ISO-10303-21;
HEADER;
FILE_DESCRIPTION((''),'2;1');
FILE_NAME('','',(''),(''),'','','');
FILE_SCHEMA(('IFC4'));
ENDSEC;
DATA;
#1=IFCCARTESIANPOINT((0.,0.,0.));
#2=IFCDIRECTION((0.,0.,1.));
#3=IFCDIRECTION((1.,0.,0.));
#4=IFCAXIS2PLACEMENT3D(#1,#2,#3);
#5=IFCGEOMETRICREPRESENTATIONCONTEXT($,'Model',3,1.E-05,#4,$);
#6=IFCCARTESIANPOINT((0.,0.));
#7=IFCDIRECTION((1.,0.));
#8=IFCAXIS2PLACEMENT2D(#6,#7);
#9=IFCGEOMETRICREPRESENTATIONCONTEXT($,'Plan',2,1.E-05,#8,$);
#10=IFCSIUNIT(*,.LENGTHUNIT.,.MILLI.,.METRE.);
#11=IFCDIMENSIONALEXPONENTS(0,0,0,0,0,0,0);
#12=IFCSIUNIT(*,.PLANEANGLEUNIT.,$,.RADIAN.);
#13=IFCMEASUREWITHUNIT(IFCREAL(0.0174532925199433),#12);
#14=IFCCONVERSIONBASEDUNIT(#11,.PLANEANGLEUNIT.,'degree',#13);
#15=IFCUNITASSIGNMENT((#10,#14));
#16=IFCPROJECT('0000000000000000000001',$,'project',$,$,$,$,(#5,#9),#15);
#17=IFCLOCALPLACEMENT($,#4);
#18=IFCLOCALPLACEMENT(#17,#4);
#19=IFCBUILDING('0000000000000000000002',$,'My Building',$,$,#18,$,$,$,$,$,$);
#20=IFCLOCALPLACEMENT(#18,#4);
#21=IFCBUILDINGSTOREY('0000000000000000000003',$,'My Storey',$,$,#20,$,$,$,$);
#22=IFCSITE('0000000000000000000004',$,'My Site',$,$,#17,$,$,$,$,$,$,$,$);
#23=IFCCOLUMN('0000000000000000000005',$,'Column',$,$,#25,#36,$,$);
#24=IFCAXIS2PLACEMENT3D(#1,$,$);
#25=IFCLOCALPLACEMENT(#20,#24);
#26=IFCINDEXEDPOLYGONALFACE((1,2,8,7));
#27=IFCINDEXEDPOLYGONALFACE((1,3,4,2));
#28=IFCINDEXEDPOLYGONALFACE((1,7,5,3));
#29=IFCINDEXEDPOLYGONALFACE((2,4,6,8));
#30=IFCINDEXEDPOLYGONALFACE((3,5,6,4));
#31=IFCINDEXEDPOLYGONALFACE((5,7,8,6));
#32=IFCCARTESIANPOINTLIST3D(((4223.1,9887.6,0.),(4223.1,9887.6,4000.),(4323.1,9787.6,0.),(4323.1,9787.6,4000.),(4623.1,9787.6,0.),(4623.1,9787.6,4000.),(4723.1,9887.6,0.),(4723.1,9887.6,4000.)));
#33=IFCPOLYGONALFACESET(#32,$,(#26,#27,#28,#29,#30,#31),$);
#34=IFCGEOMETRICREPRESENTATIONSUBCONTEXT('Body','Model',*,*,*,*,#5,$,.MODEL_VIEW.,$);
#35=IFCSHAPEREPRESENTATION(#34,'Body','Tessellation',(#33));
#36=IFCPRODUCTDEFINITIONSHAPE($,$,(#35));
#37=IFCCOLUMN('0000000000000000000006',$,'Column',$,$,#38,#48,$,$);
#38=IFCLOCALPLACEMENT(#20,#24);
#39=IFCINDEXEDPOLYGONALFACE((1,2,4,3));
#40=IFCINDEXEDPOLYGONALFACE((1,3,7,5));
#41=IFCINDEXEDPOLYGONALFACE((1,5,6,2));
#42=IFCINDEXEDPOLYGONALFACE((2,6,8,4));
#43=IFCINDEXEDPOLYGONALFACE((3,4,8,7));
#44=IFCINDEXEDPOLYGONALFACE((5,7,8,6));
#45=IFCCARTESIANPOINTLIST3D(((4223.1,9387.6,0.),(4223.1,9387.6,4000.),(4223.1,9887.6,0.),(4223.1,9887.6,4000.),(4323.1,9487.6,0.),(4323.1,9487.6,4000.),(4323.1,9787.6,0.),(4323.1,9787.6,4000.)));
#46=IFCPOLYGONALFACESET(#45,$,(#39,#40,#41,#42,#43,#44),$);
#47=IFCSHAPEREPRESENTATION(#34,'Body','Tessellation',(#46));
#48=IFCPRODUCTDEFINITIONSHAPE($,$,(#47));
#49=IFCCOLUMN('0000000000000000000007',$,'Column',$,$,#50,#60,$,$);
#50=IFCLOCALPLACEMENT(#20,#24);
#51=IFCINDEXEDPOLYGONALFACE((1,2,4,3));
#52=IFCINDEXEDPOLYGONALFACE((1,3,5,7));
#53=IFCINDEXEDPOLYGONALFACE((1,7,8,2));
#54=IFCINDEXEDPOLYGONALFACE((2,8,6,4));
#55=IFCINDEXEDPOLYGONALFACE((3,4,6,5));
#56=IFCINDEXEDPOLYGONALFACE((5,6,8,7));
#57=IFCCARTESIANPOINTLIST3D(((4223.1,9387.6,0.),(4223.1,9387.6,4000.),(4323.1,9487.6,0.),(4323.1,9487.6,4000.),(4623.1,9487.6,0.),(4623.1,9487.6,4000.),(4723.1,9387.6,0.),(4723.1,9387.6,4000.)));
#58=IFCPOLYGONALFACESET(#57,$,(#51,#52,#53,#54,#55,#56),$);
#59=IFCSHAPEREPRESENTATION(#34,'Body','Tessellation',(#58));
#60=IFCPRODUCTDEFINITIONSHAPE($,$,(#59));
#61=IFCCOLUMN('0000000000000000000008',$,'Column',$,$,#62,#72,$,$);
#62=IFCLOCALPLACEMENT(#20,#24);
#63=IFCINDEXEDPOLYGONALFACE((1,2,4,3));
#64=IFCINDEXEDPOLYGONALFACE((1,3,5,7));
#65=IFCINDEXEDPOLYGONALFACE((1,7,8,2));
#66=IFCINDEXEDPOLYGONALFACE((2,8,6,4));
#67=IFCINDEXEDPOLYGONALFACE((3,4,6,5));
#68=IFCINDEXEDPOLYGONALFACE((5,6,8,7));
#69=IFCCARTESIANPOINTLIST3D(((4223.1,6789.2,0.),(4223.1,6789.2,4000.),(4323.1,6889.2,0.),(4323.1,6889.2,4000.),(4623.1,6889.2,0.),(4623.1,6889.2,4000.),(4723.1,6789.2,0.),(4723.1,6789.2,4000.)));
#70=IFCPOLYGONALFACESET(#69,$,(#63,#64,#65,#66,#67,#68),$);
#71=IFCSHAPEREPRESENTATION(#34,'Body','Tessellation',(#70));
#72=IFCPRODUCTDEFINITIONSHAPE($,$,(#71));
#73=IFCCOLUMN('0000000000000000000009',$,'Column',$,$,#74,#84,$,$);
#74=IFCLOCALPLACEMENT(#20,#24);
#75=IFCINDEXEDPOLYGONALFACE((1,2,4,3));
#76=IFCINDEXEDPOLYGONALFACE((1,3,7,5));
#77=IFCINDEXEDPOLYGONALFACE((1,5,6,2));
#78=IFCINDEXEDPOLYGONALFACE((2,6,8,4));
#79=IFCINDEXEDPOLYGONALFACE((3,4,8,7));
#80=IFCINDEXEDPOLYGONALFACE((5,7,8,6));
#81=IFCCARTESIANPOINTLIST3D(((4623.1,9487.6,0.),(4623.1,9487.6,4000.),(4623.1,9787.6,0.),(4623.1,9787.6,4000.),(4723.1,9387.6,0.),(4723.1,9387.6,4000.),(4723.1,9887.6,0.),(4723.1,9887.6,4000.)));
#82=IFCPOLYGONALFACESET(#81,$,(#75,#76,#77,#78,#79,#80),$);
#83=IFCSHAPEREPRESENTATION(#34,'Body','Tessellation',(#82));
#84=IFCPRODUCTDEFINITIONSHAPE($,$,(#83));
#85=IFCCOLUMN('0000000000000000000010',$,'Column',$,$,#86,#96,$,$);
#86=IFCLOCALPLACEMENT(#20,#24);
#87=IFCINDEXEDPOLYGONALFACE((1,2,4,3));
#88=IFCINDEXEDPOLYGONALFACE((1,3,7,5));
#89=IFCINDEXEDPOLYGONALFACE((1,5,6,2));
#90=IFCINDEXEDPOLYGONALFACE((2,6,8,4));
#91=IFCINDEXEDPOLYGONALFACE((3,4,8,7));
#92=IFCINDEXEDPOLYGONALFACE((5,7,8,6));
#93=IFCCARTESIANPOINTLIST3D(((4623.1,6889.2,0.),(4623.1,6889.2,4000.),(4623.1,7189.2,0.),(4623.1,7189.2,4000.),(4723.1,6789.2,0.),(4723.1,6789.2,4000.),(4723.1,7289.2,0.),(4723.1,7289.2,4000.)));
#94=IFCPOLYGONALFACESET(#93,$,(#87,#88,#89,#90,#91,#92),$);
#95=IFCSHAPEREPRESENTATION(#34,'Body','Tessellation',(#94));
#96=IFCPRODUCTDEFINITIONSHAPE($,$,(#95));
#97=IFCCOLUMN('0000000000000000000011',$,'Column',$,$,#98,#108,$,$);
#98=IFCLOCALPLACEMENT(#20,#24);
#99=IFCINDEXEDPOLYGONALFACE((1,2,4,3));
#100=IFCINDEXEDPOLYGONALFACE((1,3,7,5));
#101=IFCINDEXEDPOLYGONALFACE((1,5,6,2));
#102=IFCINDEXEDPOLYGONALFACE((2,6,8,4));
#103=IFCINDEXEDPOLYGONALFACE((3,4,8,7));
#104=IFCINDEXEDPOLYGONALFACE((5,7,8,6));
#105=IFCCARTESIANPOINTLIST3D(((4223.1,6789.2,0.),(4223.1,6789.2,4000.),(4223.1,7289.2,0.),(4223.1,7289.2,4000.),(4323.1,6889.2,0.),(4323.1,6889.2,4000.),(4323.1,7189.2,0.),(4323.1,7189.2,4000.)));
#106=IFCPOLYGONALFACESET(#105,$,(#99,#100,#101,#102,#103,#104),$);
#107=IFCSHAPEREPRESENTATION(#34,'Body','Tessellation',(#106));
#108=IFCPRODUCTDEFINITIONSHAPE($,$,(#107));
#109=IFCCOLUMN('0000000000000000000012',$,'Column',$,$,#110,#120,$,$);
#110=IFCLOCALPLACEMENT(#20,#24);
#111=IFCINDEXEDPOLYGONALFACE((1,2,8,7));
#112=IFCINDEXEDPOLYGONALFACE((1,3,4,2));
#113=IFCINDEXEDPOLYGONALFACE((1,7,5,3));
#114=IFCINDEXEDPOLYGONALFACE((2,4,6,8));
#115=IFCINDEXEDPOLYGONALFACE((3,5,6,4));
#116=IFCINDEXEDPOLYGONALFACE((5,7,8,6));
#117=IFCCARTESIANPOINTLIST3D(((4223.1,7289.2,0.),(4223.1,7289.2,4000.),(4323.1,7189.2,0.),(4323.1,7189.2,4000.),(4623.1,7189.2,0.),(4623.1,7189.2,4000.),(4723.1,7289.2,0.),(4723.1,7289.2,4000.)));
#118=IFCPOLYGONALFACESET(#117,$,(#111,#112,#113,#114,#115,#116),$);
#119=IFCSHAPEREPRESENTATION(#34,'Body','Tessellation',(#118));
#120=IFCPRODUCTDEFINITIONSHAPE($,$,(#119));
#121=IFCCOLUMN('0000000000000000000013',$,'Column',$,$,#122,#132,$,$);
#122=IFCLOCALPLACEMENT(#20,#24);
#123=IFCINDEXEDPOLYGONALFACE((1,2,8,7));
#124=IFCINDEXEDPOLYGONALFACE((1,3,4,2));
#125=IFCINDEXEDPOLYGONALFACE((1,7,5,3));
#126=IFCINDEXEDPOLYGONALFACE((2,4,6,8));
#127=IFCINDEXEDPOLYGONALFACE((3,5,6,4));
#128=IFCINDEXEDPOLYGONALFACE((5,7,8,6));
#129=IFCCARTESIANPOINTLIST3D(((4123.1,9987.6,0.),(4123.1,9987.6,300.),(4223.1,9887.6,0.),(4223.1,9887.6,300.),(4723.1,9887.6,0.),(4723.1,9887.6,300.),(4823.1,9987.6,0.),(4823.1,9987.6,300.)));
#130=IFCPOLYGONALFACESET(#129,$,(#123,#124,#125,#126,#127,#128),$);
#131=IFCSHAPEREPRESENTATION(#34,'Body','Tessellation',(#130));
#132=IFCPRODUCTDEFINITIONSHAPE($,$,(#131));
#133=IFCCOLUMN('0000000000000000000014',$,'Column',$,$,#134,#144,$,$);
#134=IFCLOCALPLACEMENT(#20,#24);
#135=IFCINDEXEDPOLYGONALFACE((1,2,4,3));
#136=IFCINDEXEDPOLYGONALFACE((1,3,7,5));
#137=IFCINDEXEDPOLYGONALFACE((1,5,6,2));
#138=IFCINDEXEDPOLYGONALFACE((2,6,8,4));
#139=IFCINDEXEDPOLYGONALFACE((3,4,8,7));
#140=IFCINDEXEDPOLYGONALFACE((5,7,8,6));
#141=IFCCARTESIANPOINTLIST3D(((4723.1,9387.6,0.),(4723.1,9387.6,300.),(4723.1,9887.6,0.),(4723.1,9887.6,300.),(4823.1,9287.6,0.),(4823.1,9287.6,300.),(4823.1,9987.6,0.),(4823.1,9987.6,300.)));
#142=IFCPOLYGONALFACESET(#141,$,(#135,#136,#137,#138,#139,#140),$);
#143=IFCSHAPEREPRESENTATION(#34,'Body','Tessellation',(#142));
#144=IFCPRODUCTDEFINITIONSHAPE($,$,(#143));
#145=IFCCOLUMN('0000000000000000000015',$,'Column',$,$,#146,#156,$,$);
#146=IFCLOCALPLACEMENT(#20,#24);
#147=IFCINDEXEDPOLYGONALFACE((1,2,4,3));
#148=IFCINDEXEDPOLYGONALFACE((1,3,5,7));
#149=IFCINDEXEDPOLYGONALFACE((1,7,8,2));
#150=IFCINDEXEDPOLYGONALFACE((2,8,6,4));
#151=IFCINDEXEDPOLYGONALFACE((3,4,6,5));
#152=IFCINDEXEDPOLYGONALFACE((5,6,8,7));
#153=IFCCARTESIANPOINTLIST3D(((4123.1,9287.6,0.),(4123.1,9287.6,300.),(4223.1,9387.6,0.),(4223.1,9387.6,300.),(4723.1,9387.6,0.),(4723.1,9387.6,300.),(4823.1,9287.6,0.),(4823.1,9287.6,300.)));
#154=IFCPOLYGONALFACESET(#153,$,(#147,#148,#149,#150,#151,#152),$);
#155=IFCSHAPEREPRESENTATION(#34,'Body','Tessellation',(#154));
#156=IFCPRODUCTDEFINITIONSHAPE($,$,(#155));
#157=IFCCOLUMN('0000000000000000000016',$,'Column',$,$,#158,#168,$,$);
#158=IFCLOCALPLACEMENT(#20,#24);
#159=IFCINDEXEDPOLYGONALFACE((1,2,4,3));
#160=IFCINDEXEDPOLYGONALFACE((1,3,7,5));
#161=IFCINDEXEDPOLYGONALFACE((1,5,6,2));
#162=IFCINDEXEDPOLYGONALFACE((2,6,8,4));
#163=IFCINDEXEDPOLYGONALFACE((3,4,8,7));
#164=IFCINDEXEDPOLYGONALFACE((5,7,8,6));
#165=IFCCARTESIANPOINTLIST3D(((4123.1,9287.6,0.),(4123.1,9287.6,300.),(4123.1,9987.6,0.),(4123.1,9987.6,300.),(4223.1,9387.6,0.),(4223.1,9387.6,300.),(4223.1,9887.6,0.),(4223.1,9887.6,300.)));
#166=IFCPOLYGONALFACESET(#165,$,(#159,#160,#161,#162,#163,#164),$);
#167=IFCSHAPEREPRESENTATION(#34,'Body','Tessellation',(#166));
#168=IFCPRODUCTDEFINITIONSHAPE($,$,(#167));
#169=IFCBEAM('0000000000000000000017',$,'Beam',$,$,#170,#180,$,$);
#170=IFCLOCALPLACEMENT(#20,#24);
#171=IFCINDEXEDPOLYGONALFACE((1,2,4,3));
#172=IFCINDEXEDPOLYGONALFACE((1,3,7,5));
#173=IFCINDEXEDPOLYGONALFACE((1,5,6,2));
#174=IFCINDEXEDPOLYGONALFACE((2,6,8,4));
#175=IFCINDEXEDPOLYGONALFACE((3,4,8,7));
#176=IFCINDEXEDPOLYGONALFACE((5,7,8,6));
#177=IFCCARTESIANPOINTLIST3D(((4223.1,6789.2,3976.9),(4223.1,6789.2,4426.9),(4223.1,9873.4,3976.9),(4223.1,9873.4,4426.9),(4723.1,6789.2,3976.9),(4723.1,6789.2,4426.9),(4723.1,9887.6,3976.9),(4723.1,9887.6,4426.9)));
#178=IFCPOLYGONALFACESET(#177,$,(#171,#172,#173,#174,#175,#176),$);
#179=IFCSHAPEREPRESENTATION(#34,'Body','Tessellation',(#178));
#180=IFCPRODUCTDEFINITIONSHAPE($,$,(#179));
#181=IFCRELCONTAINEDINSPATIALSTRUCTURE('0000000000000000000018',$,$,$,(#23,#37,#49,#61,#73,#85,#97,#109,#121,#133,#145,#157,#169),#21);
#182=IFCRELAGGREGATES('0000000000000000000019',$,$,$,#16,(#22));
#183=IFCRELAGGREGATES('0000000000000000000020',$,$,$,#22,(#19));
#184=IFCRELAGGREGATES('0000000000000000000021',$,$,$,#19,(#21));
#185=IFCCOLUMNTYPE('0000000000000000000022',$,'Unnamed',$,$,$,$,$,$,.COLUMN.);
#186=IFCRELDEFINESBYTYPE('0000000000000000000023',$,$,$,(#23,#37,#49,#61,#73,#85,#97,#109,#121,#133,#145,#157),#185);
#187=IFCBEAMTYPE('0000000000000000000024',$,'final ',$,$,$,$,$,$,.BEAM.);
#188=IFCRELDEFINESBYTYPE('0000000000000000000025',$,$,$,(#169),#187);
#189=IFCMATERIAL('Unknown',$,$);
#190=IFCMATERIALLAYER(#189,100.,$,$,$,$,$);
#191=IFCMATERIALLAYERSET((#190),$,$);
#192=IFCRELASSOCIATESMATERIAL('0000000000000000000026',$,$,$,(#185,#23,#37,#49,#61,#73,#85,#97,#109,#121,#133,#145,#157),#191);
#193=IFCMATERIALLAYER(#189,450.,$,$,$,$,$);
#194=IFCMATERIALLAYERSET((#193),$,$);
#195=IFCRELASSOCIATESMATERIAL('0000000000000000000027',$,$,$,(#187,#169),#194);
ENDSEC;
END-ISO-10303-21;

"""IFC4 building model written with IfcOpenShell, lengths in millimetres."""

from ifc_helpers import new_model, entity, si_unit, converted_unit, frame, origin_with_axes, origin_2d_with_axis, place, context, subcontext, project, spatial, line, indexed_curve, outline, extrude, material, layer, layer_set, layer_usage, type_object, element, save


model = new_model("IFC4")

# Units and contexts
model_context = context("Model", 3, precision=1e-05, world=origin_with_axes())
plan_context = context("Plan", 2, precision=1e-05, world=origin_2d_with_axis())
body_context = subcontext(model_context, "Body", "Model", "MODEL_VIEW")
ifc_project = project(units=[si_unit("LENGTHUNIT", "METRE", prefix="MILLI"), converted_unit("PLANEANGLEUNIT", "degree", entity("IfcReal", 0.0174532925199433), si_unit("PLANEANGLEUNIT", "RADIAN"), dimensions=[0, 0, 0, 0, 0, 0, 0])], contexts=[model_context, plan_context])

# Site, building, storey
site_placement = place(None, origin_with_axes())
site = spatial("IfcSite", under=ifc_project, at=site_placement, Name="My Site")
building_placement = place(site_placement, origin_with_axes())
building = spatial("IfcBuilding", under=site, at=building_placement, Name="My Building")
storey_placement = place(building_placement, origin_with_axes())
storey = spatial("IfcBuildingStorey", under=building, at=storey_placement, Name="My Storey")

# Columns
ifc_material = material(Name="Unknown")
ifc_layer_1 = layer(ifc_material, 100.0)
ifc_layer_set_1 = layer_set([ifc_layer_1])
ifc_layer_usage_1 = layer_usage(ifc_layer_set_1, "AXIS2", "POSITIVE", 0.0)
column_type = type_object("IfcColumnType", Name="Unnamed", PredefinedType="COLUMN", material=ifc_layer_set_1)
column_1_placement = place(storey_placement, frame((4323.1, 9787.6, 0.0), z_axis=(0.0, 0.0, 1.0), x_axis=(1.0, 0.0, 0.0)))
element("IfcColumn", 1, at=column_1_placement, inside=storey, type_object=column_type, material=ifc_layer_usage_1, Name="Column", context=body_context, shape_type="SweptSolid", body=[
    extrude(outline(indexed_curve([(0.0, 0.0), (-100.0, 100.0), (400.0, 100.0), (300.0, 0.0)], segments=[line(1, 2, 3, 4, 1)])), origin_with_axes(), (0.0, 0.0, 1.0), 4000.0),
])
ifc_layer_usage_2 = layer_usage(ifc_layer_set_1, "AXIS2", "POSITIVE", 0.0)
column_2_placement = place(storey_placement, frame((4323.1, 9487.6, 0.0), z_axis=(0.0, 0.0, 1.0), x_axis=(0.0, 1.0, 0.0)))
element("IfcColumn", 2, at=column_2_placement, inside=storey, type_object=column_type, material=ifc_layer_usage_2, Name="Column", context=body_context, shape_type="SweptSolid", body=[
    extrude(outline(indexed_curve([(0.0, 0.0), (-100.0, 100.0), (400.0, 100.0), (300.0, 0.0)], segments=[line(1, 2, 3, 4, 1)])), origin_with_axes(), (0.0, 0.0, 1.0), 4000.0),
])
ifc_layer_usage_3 = layer_usage(ifc_layer_set_1, "AXIS2", "POSITIVE", 0.0)
column_3_placement = place(storey_placement, frame((4623.1, 9487.6, 0.0), z_axis=(0.0, 0.0, 1.0), x_axis=(-1.0, 0.0, 0.0)))
element("IfcColumn", 3, at=column_3_placement, inside=storey, type_object=column_type, material=ifc_layer_usage_3, Name="Column", context=body_context, shape_type="SweptSolid", body=[
    extrude(outline(indexed_curve([(0.0, 0.0), (-100.0, 100.0), (400.0, 100.0), (300.0, 0.0)], segments=[line(1, 2, 3, 4, 1)])), origin_with_axes(), (0.0, 0.0, 1.0), 4000.0),
])
ifc_layer_usage_4 = layer_usage(ifc_layer_set_1, "AXIS2", "POSITIVE", 0.0)
column_4_placement = place(storey_placement, frame((4623.1, 6889.2, 0.0), z_axis=(0.0, 0.0, 1.0), x_axis=(-1.0, 0.0, 0.0)))
element("IfcColumn", 4, at=column_4_placement, inside=storey, type_object=column_type, material=ifc_layer_usage_4, Name="Column", context=body_context, shape_type="SweptSolid", body=[
    extrude(outline(indexed_curve([(0.0, 0.0), (-100.0, 100.0), (400.0, 100.0), (300.0, 0.0)], segments=[line(1, 2, 3, 4, 1)])), origin_with_axes(), (0.0, 0.0, 1.0), 4000.0),
])
ifc_layer_usage_5 = layer_usage(ifc_layer_set_1, "AXIS2", "POSITIVE", 0.0)
column_5_placement = place(storey_placement, frame((4623.1, 9787.6, 0.0), z_axis=(0.0, 0.0, 1.0), x_axis=(0.0, -1.0, 0.0)))
element("IfcColumn", 5, at=column_5_placement, inside=storey, type_object=column_type, material=ifc_layer_usage_5, Name="Column", context=body_context, shape_type="SweptSolid", body=[
    extrude(outline(indexed_curve([(0.0, 0.0), (-100.0, 100.0), (400.0, 100.0), (300.0, 0.0)], segments=[line(1, 2, 3, 4, 1)])), origin_with_axes(), (0.0, 0.0, 1.0), 4000.0),
])
ifc_layer_usage_6 = layer_usage(ifc_layer_set_1, "AXIS2", "POSITIVE", 0.0)
column_6_placement = place(storey_placement, frame((4623.1, 7189.2, 0.0), z_axis=(0.0, 0.0, 1.0), x_axis=(0.0, -1.0, 0.0)))
element("IfcColumn", 6, at=column_6_placement, inside=storey, type_object=column_type, material=ifc_layer_usage_6, Name="Column", context=body_context, shape_type="SweptSolid", body=[
    extrude(outline(indexed_curve([(0.0, 0.0), (-100.0, 100.0), (400.0, 100.0), (300.0, 0.0)], segments=[line(1, 2, 3, 4, 1)])), origin_with_axes(), (0.0, 0.0, 1.0), 4000.0),
])
ifc_layer_usage_7 = layer_usage(ifc_layer_set_1, "AXIS2", "POSITIVE", 0.0)
column_7_placement = place(storey_placement, frame((4323.1, 6889.2, 0.0), z_axis=(0.0, 0.0, 1.0), x_axis=(0.0, 1.0, 0.0)))
element("IfcColumn", 7, at=column_7_placement, inside=storey, type_object=column_type, material=ifc_layer_usage_7, Name="Column", context=body_context, shape_type="SweptSolid", body=[
    extrude(outline(indexed_curve([(0.0, 0.0), (-100.0, 100.0), (400.0, 100.0), (300.0, 0.0)], segments=[line(1, 2, 3, 4, 1)])), origin_with_axes(), (0.0, 0.0, 1.0), 4000.0),
])
ifc_layer_usage_8 = layer_usage(ifc_layer_set_1, "AXIS2", "POSITIVE", 0.0)
column_8_placement = place(storey_placement, frame((4323.1, 7189.2, 0.0), z_axis=(0.0, 0.0, 1.0), x_axis=(1.0, 0.0, 0.0)))
element("IfcColumn", 8, at=column_8_placement, inside=storey, type_object=column_type, material=ifc_layer_usage_8, Name="Column", context=body_context, shape_type="SweptSolid", body=[
    extrude(outline(indexed_curve([(0.0, 0.0), (-100.0, 100.0), (400.0, 100.0), (300.0, 0.0)], segments=[line(1, 2, 3, 4, 1)])), origin_with_axes(), (0.0, 0.0, 1.0), 4000.0),
])
ifc_layer_usage_9 = layer_usage(ifc_layer_set_1, "AXIS2", "POSITIVE", 0.0)
column_9_placement = place(storey_placement, frame((4223.1, 9887.6, 0.0), z_axis=(0.0, 0.0, 1.0), x_axis=(1.0, 0.0, 0.0)))
element("IfcColumn", 9, at=column_9_placement, inside=storey, type_object=column_type, material=ifc_layer_usage_9, Name="Column", context=body_context, shape_type="SweptSolid", body=[
    extrude(outline(indexed_curve([(0.0, 0.0), (-100.0, 100.0), (600.0, 100.0), (500.0, 0.0)], segments=[line(1, 2, 3, 4, 1)])), origin_with_axes(), (0.0, 0.0, 1.0), 300.0),
])
ifc_layer_usage_10 = layer_usage(ifc_layer_set_1, "AXIS2", "POSITIVE", 0.0)
column_10_placement = place(storey_placement, frame((4723.1, 9887.6, 0.0), z_axis=(0.0, 0.0, 1.0), x_axis=(0.0, -1.0, 0.0)))
element("IfcColumn", 10, at=column_10_placement, inside=storey, type_object=column_type, material=ifc_layer_usage_10, Name="Column", context=body_context, shape_type="SweptSolid", body=[
    extrude(outline(indexed_curve([(0.0, 0.0), (-100.0, 100.0), (600.0, 100.0), (500.0, 0.0)], segments=[line(1, 2, 3, 4, 1)])), origin_with_axes(), (0.0, 0.0, 1.0), 300.0),
])
ifc_layer_usage_11 = layer_usage(ifc_layer_set_1, "AXIS2", "POSITIVE", 0.0)
column_11_placement = place(storey_placement, frame((4723.1, 9387.6, 0.0), z_axis=(0.0, 0.0, 1.0), x_axis=(-1.0, 0.0, 0.0)))
element("IfcColumn", 11, at=column_11_placement, inside=storey, type_object=column_type, material=ifc_layer_usage_11, Name="Column", context=body_context, shape_type="SweptSolid", body=[
    extrude(outline(indexed_curve([(0.0, 0.0), (-100.0, 100.0), (600.0, 100.0), (500.0, 0.0)], segments=[line(1, 2, 3, 4, 1)])), origin_with_axes(), (0.0, 0.0, 1.0), 300.0),
])
ifc_layer_usage_12 = layer_usage(ifc_layer_set_1, "AXIS2", "POSITIVE", 0.0)
column_12_placement = place(storey_placement, frame((4223.1, 9387.6, 0.0), z_axis=(0.0, 0.0, 1.0), x_axis=(0.0, 1.0, 0.0)))
element("IfcColumn", 12, at=column_12_placement, inside=storey, type_object=column_type, material=ifc_layer_usage_12, Name="Column", context=body_context, shape_type="SweptSolid", body=[
    extrude(outline(indexed_curve([(0.0, 0.0), (-100.0, 100.0), (600.0, 100.0), (500.0, 0.0)], segments=[line(1, 2, 3, 4, 1)])), origin_with_axes(), (0.0, 0.0, 1.0), 300.0),
])

# Beam
ifc_layer_2 = layer(ifc_material, 450.0)
ifc_layer_set_2 = layer_set([ifc_layer_2])
ifc_layer_usage_13 = layer_usage(ifc_layer_set_2, "AXIS3", "POSITIVE", -450.0)
beam_type = type_object("IfcBeamType", Name="final ", PredefinedType="BEAM", material=ifc_layer_set_2)
beam_placement = place(storey_placement, frame((4723.1, 9887.6, 4426.9), z_axis=(0.0, 0.0, 1.0), x_axis=(1.0, 0.0, 0.0)))
element("IfcBeam", 13, at=beam_placement, inside=storey, type_object=beam_type, material=ifc_layer_usage_13, Name="Beam", context=body_context, shape_type="SweptSolid", body=[
    extrude(outline(indexed_curve([(0.0, 0.0), (0.0, -3098.3), (-500.0, -3098.3), (-500.0, -14.2), (0.0, 0.0)])), frame((0.0, 0.0, -450.0), z_axis=(0.0, 0.0, 1.0), x_axis=(1.0, 0.0, 0.0)), (0.0, 0.0, 1.0), 450.0),
])

save(model, "model.ifc")
